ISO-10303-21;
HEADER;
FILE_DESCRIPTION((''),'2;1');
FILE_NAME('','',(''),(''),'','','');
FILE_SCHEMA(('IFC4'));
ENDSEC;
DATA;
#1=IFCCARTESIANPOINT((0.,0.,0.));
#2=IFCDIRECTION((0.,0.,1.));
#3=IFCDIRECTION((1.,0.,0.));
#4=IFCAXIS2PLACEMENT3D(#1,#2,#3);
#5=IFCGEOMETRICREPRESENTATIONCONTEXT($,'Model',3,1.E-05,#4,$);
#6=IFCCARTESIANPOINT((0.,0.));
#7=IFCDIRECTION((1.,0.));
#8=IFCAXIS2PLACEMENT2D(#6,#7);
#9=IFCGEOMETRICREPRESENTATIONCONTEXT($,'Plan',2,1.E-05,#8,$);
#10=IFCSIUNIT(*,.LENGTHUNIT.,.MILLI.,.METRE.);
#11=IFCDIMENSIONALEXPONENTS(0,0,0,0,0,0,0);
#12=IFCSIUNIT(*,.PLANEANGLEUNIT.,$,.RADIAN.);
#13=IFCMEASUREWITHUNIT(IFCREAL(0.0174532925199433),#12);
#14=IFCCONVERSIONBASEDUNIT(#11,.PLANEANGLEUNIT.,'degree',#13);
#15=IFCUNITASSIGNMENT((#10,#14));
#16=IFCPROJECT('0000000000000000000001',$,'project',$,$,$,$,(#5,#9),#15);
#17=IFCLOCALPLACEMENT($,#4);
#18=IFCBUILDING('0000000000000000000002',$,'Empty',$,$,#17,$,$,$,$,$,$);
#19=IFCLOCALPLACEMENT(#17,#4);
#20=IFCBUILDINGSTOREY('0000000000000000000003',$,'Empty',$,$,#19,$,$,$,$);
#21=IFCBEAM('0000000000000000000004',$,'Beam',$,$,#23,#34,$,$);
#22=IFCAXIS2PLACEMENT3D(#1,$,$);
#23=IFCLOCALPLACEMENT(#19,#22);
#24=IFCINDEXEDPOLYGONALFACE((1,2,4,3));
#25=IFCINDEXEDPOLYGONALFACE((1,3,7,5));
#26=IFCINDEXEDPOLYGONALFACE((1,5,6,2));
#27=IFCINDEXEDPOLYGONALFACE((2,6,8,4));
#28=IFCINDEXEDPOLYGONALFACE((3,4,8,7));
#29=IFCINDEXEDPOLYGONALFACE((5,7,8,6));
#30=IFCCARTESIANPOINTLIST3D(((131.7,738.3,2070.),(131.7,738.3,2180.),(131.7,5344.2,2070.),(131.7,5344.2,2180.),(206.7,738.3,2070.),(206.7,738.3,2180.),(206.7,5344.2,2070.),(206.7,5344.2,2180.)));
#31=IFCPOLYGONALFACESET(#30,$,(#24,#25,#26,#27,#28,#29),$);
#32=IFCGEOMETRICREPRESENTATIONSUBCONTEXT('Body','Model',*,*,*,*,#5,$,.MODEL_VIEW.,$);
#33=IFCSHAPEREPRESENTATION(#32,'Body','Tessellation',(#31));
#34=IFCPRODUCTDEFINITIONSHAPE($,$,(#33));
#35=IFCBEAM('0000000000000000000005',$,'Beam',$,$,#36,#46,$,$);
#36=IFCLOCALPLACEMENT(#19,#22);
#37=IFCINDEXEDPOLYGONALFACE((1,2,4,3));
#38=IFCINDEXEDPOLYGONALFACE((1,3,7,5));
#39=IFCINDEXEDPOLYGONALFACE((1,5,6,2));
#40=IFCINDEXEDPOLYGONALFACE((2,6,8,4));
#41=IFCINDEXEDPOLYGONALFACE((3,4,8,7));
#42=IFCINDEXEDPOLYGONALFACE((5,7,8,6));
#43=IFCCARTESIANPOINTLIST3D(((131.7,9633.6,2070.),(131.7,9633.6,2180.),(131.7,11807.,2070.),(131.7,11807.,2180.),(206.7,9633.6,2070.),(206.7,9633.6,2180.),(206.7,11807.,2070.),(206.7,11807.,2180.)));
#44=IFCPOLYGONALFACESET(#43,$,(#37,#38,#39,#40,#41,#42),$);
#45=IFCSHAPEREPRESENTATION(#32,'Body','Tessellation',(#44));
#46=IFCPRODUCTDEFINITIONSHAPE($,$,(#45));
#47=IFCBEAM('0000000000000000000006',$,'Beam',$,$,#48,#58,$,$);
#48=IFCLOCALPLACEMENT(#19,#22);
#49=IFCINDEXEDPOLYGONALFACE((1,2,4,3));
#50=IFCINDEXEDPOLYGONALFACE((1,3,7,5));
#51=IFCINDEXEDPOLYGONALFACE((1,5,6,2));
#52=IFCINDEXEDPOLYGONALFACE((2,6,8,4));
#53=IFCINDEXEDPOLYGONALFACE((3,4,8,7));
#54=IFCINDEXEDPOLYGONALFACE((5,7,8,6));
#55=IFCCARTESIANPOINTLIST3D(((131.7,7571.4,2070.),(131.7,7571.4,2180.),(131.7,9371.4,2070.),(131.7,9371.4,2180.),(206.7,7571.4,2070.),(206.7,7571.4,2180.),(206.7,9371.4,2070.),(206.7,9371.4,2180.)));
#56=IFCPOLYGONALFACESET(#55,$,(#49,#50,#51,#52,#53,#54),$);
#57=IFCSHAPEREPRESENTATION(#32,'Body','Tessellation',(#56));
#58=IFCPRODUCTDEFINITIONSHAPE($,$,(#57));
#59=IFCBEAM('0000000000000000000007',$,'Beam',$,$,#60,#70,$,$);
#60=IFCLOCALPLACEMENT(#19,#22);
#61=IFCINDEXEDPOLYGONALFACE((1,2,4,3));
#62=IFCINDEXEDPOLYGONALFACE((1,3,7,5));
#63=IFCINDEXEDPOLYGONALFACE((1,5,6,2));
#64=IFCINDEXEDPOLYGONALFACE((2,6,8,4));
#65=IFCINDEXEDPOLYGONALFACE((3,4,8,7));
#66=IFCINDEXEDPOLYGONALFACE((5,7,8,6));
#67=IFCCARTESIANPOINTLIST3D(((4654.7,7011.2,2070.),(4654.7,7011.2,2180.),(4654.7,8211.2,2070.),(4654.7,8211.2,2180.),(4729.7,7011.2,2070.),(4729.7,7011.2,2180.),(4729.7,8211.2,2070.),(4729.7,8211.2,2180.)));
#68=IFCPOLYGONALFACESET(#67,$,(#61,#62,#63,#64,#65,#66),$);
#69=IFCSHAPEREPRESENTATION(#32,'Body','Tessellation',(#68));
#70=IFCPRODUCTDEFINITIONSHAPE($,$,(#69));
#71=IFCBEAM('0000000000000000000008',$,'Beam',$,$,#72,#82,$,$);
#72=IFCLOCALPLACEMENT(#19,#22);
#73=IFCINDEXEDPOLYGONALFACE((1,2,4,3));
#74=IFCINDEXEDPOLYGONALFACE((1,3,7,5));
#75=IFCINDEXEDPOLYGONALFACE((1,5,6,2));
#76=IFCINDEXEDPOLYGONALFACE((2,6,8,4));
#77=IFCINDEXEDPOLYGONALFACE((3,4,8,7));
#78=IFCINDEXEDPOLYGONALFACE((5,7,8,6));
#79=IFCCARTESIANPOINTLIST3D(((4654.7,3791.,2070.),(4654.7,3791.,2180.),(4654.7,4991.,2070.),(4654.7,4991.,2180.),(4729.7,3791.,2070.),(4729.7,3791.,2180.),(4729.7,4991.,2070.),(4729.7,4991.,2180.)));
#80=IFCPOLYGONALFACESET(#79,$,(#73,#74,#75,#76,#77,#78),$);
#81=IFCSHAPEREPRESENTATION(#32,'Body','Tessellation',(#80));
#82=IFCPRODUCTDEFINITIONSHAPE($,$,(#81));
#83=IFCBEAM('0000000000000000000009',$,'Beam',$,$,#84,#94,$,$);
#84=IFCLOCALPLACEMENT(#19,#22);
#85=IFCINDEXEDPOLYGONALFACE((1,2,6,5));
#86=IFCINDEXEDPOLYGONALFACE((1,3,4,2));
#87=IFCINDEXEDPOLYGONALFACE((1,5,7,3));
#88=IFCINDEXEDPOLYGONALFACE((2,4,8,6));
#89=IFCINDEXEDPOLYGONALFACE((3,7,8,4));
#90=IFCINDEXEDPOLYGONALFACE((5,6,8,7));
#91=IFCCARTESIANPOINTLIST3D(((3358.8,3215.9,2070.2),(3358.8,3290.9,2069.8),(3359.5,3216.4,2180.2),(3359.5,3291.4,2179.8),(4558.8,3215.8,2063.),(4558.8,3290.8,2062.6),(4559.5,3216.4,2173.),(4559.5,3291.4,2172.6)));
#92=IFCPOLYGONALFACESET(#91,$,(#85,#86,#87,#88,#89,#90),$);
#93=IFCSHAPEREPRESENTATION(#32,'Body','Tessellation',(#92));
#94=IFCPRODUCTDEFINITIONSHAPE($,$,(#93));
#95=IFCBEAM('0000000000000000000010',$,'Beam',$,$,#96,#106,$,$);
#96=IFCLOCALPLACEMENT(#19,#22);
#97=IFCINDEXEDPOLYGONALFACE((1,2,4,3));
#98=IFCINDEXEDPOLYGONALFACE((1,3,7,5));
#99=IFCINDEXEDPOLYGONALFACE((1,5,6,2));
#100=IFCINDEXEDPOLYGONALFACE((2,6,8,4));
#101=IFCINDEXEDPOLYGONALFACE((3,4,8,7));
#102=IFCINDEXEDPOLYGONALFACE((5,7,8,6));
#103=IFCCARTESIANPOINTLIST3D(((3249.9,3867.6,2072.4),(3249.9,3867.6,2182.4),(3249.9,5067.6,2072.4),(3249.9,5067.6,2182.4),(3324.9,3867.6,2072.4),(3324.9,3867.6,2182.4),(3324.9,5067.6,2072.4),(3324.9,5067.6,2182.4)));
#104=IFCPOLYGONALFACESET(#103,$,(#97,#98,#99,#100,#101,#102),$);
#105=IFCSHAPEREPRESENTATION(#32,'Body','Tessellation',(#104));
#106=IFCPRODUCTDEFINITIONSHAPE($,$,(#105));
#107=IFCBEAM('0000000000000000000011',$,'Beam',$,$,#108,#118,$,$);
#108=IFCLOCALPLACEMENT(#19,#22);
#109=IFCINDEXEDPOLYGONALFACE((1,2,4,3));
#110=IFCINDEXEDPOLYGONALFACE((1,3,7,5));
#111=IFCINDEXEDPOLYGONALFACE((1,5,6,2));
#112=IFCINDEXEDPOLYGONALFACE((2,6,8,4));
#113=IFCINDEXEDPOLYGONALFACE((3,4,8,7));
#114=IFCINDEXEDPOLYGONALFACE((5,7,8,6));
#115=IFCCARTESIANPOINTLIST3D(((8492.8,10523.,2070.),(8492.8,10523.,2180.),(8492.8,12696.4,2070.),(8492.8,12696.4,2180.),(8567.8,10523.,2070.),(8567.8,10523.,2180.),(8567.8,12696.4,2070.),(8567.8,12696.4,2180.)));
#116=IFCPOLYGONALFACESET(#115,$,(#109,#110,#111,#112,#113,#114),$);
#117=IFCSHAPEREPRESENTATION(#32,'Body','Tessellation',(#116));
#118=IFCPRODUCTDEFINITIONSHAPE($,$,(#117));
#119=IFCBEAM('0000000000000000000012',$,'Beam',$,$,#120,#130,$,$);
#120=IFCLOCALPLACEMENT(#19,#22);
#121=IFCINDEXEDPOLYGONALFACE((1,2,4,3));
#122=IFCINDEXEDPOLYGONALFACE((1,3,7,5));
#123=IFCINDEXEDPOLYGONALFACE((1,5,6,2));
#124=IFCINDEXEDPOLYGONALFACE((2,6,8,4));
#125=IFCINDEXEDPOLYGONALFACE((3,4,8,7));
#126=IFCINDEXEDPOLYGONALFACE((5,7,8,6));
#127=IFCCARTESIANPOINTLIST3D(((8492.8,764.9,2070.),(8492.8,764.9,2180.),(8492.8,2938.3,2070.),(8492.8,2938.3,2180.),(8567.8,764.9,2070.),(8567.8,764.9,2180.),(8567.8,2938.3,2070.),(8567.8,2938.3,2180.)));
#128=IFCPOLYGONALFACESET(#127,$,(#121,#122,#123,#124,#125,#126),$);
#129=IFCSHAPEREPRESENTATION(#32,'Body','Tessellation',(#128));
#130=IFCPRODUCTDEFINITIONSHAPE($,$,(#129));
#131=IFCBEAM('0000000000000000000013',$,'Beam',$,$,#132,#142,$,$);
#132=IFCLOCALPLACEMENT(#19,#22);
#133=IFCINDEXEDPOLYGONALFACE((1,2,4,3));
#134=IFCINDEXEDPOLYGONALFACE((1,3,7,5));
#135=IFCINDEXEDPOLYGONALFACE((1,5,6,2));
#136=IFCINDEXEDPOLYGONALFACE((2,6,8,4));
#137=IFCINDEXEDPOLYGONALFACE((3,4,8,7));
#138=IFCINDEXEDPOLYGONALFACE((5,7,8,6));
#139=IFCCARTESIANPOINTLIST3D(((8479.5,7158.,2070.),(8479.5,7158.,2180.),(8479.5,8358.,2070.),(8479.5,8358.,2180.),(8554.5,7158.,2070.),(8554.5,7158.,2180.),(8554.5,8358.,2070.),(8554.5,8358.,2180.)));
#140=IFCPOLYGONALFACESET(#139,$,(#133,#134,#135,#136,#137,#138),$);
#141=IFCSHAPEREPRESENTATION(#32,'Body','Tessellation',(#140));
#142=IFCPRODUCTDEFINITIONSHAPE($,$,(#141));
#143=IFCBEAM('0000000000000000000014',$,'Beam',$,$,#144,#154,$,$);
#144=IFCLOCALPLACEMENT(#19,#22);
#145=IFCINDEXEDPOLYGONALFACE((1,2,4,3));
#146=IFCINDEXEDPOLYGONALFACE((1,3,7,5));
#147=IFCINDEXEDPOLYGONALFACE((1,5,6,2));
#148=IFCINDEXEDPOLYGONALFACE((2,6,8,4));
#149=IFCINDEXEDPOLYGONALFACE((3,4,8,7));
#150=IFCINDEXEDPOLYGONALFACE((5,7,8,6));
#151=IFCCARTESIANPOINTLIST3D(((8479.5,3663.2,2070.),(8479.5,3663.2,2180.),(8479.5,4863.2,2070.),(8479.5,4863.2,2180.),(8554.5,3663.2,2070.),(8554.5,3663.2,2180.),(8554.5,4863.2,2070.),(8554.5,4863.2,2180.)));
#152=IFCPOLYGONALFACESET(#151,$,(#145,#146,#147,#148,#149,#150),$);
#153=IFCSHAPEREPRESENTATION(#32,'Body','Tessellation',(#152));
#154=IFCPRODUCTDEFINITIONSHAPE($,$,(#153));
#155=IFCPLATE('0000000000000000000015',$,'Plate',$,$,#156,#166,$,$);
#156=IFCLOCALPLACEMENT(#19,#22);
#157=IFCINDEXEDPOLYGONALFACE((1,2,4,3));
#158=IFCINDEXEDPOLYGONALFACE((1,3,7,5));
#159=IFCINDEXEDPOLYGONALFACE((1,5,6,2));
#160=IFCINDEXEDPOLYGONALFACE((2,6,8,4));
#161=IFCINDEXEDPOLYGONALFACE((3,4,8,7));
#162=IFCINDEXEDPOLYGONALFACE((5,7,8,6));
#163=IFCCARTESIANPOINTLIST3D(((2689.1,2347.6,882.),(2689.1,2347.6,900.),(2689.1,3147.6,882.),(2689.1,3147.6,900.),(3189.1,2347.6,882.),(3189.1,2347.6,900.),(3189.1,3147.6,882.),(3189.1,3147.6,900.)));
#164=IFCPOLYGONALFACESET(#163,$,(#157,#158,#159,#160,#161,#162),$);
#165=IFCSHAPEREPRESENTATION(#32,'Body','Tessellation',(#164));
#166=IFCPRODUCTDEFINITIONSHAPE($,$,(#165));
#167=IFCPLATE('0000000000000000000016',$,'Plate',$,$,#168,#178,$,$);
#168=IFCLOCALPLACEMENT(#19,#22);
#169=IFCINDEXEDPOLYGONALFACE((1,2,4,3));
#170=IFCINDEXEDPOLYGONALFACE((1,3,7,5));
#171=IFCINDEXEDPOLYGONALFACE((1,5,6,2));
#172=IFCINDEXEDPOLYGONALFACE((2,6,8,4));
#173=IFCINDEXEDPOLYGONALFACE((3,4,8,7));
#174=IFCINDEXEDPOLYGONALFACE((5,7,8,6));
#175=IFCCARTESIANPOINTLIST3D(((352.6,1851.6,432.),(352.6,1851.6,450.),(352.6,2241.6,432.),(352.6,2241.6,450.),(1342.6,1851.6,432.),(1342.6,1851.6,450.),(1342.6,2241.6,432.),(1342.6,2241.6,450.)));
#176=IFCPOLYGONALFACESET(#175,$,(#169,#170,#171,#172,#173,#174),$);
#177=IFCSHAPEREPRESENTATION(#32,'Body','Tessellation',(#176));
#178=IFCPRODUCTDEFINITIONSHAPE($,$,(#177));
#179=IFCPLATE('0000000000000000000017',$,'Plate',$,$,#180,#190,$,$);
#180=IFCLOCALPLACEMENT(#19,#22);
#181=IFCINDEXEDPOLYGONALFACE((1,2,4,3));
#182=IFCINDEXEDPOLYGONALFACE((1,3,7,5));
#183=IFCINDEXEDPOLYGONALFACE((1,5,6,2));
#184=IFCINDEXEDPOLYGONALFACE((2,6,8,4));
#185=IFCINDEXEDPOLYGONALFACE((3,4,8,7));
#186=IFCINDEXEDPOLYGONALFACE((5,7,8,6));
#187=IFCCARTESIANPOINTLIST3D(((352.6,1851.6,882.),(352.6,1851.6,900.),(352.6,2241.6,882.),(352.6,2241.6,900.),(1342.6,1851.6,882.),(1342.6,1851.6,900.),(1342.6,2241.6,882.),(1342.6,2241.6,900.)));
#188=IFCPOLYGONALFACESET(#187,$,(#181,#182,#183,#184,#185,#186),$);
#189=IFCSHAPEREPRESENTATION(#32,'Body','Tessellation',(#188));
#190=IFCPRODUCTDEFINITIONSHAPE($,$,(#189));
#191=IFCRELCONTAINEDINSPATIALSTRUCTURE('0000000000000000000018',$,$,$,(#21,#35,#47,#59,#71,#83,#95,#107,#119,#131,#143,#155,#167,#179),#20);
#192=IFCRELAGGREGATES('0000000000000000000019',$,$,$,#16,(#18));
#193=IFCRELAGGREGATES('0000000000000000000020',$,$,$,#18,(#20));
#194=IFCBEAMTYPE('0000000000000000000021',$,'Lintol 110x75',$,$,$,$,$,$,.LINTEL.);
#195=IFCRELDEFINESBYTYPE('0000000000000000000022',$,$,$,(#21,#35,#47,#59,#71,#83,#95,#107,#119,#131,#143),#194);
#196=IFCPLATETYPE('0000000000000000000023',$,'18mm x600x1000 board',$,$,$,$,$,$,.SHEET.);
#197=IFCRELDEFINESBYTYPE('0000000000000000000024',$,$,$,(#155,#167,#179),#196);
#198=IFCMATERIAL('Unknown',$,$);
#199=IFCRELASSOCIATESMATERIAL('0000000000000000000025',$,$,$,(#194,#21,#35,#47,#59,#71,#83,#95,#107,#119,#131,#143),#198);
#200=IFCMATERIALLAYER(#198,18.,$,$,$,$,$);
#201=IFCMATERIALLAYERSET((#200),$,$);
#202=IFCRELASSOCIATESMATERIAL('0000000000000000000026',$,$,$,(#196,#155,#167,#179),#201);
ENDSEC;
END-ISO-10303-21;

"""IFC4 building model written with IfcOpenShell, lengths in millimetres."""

from ifc_helpers import new_model, entity, si_unit, converted_unit, frame, origin_with_axes, origin_2d_with_axis, place, context, subcontext, project, spatial, line, indexed_curve, rectangle, outline, extrude, material, layer, layer_set, layer_usage, material_profile, profile_set, profile_usage, type_object, element, save


model = new_model("IFC4")

# Units and contexts
model_context = context("Model", 3, precision=1e-05, world=origin_with_axes())
plan_context = context("Plan", 2, precision=1e-05, world=origin_2d_with_axis())
body_context = subcontext(model_context, "Body", "Model", "MODEL_VIEW")
ifc_project = project(units=[si_unit("LENGTHUNIT", "METRE", prefix="MILLI"), converted_unit("PLANEANGLEUNIT", "degree", entity("IfcReal", 0.0174532925199433), si_unit("PLANEANGLEUNIT", "RADIAN"), dimensions=[0, 0, 0, 0, 0, 0, 0])], contexts=[model_context, plan_context])

# Building, storey
building_placement = place(None, origin_with_axes())
building = spatial("IfcBuilding", under=ifc_project, at=building_placement, Name="Empty")
storey_placement = place(building_placement, origin_with_axes())
storey = spatial("IfcBuildingStorey", under=building, at=storey_placement, Name="Empty")

# Beams
ifc_material_1 = material(Name="Unknown")
ifc_material_profile_1 = material_profile(ifc_material_1, rectangle(XDim=75.0, YDim=110.0))
ifc_profile_set_1 = profile_set([ifc_material_profile_1])
ifc_profile_usage_1 = profile_usage(ifc_profile_set_1, cardinal=5)
beam_type = type_object("IfcBeamType", Name="Lintol 110x75", PredefinedType="LINTEL", material=ifc_profile_set_1)
beam_1_placement = place(storey_placement, frame((169.2, 738.3, 2125.0), z_axis=(0.0, 1.0, 0.0), x_axis=(-1.0, 0.0, 0.0)))
element("IfcBeam", 1, at=beam_1_placement, inside=storey, type_object=beam_type, material=ifc_profile_usage_1, Name="Beam", context=body_context, shape_type="SweptSolid", body=[
    extrude(rectangle(XDim=75.0, YDim=110.0), origin_with_axes(), (0.0, 0.0, 1.0), 4605.9),
])
ifc_profile_usage_2 = profile_usage(ifc_profile_set_1, cardinal=5)
beam_2_placement = place(storey_placement, frame((169.2, 9633.6, 2125.0), z_axis=(-0.000001, 1.0, 0.0), x_axis=(-1.0, -0.000001, 0.0)))
element("IfcBeam", 2, at=beam_2_placement, inside=storey, type_object=beam_type, material=ifc_profile_usage_2, Name="Beam", context=body_context, shape_type="SweptSolid", body=[
    extrude(rectangle(XDim=75.0, YDim=110.0), origin_with_axes(), (0.0, 0.0, 1.0), 2173.4),
])
ifc_profile_usage_3 = profile_usage(ifc_profile_set_1, cardinal=5)
beam_3_placement = place(storey_placement, frame((169.2, 9371.4, 2125.0), z_axis=(-0.000001, -1.0, 0.0), x_axis=(1.0, -0.000001, 0.0)))
element("IfcBeam", 3, at=beam_3_placement, inside=storey, type_object=beam_type, material=ifc_profile_usage_3, Name="Beam", context=body_context, shape_type="SweptSolid", body=[
    extrude(rectangle(XDim=75.0, YDim=110.0), origin_with_axes(), (0.0, 0.0, 1.0), 1800.0),
])
ifc_profile_usage_4 = profile_usage(ifc_profile_set_1, cardinal=5)
beam_4_placement = place(storey_placement, frame((4692.2, 8211.2, 2125.0), z_axis=(0.000001, -1.0, 0.000001), x_axis=(1.0, 0.000001, 0.0)))
element("IfcBeam", 4, at=beam_4_placement, inside=storey, type_object=beam_type, material=ifc_profile_usage_4, Name="Beam", context=body_context, shape_type="SweptSolid", body=[
    extrude(rectangle(XDim=75.0, YDim=110.0), origin_with_axes(), (0.0, 0.0, 1.0), 1200.0),
])
ifc_profile_usage_5 = profile_usage(ifc_profile_set_1, cardinal=5)
beam_5_placement = place(storey_placement, frame((4692.2, 4991.0, 2125.0), z_axis=(0.000001, -1.0, 0.000001), x_axis=(1.0, 0.000001, 0.0)))
element("IfcBeam", 5, at=beam_5_placement, inside=storey, type_object=beam_type, material=ifc_profile_usage_5, Name="Beam", context=body_context, shape_type="SweptSolid", body=[
    extrude(rectangle(XDim=75.0, YDim=110.0), origin_with_axes(), (0.0, 0.0, 1.0), 1200.0),
])
ifc_profile_usage_6 = profile_usage(ifc_profile_set_1, cardinal=5)
beam_6_placement = place(storey_placement, frame((3359.2, 3253.6, 2125.0), z_axis=(0.999982, -0.000031, -0.006032), x_axis=(0.0, 0.999987, -0.005098)))
element("IfcBeam", 6, at=beam_6_placement, inside=storey, type_object=beam_type, material=ifc_profile_usage_6, Name="Beam", context=body_context, shape_type="SweptSolid", body=[
    extrude(rectangle(XDim=75.0, YDim=110.0), origin_with_axes(), (0.0, 0.0, 1.0), 1200.0),
])
ifc_profile_usage_7 = profile_usage(ifc_profile_set_1, cardinal=5)
beam_7_placement = place(storey_placement, frame((3287.4, 5067.6, 2127.4), z_axis=(0.0, -1.0, 0.0), x_axis=(1.0, 0.0, 0.0)))
element("IfcBeam", 7, at=beam_7_placement, inside=storey, type_object=beam_type, material=ifc_profile_usage_7, Name="Beam", context=body_context, shape_type="SweptSolid", body=[
    extrude(rectangle(XDim=75.0, YDim=110.0), origin_with_axes(), (0.0, 0.0, 1.0), 1200.0),
])
ifc_profile_usage_8 = profile_usage(ifc_profile_set_1, cardinal=5)
beam_8_placement = place(storey_placement, frame((8530.3, 10523.0, 2125.0), z_axis=(0.0, 1.0, 0.0), x_axis=(-1.0, 0.0, 0.0)))
element("IfcBeam", 8, at=beam_8_placement, inside=storey, type_object=beam_type, material=ifc_profile_usage_8, Name="Beam", context=body_context, shape_type="SweptSolid", body=[
    extrude(rectangle(XDim=75.0, YDim=110.0), origin_with_axes(), (0.0, 0.0, 1.0), 2173.4),
])
ifc_profile_usage_9 = profile_usage(ifc_profile_set_1, cardinal=5)
beam_9_placement = place(storey_placement, frame((8530.3, 764.9, 2125.0), z_axis=(0.0, 1.0, 0.0), x_axis=(-1.0, 0.0, 0.0)))
element("IfcBeam", 9, at=beam_9_placement, inside=storey, type_object=beam_type, material=ifc_profile_usage_9, Name="Beam", context=body_context, shape_type="SweptSolid", body=[
    extrude(rectangle(XDim=75.0, YDim=110.0), origin_with_axes(), (0.0, 0.0, 1.0), 2173.4),
])
ifc_profile_usage_10 = profile_usage(ifc_profile_set_1, cardinal=5)
beam_10_placement = place(storey_placement, frame((8517.0, 8358.0, 2125.0), z_axis=(0.000001, -1.0, 0.000001), x_axis=(1.0, 0.000001, 0.0)))
element("IfcBeam", 10, at=beam_10_placement, inside=storey, type_object=beam_type, material=ifc_profile_usage_10, Name="Beam", context=body_context, shape_type="SweptSolid", body=[
    extrude(rectangle(XDim=75.0, YDim=110.0), origin_with_axes(), (0.0, 0.0, 1.0), 1200.0),
])
ifc_profile_usage_11 = profile_usage(ifc_profile_set_1, cardinal=5)
beam_11_placement = place(storey_placement, frame((8517.0, 4863.2, 2125.0), z_axis=(0.000001, -1.0, 0.000001), x_axis=(1.0, 0.000001, 0.0)))
element("IfcBeam", 11, at=beam_11_placement, inside=storey, type_object=beam_type, material=ifc_profile_usage_11, Name="Beam", context=body_context, shape_type="SweptSolid", body=[
    extrude(rectangle(XDim=75.0, YDim=110.0), origin_with_axes(), (0.0, 0.0, 1.0), 1200.0),
])

# Plates
ifc_layer_1 = layer(ifc_material_1, 18.0)
ifc_layer_set_1 = layer_set([ifc_layer_1])
plate_type = type_object("IfcPlateType", Name="18mm x600x1000 board", PredefinedType="SHEET", material=ifc_layer_set_1)
ifc_layer_usage_1 = layer_usage(ifc_layer_set_1, "AXIS3", "POSITIVE", 0.0)
plate_1_placement = place(storey_placement, frame((2689.1, 3147.6, 882.0), z_axis=(0.0, 0.0, 1.0), x_axis=(0.000002, -1.0, 0.0)))
element("IfcPlate", 12, at=plate_1_placement, inside=storey, type_object=plate_type, material=ifc_layer_usage_1, Name="Plate", context=body_context, shape_type="SweptSolid", body=[
    extrude(outline(indexed_curve([(0.0, 500.0), (0.0, 0.0), (800.0, 0.0), (800.0, 500.0)], segments=[line(3, 2), line(2, 1), line(1, 4), line(4, 3)], self_intersect=False)), None, (0.0, 0.0, 1.0), 18.0),
])
ifc_layer_usage_2 = layer_usage(ifc_layer_set_1, "AXIS3", "POSITIVE", 0.0)
plate_2_placement = place(storey_placement, frame((352.6, 1851.6, 432.0), z_axis=(0.0, 0.0, 1.0), x_axis=(1.0, 0.000001, 0.0)))
element("IfcPlate", 13, at=plate_2_placement, inside=storey, type_object=plate_type, material=ifc_layer_usage_2, Name="Plate", context=body_context, shape_type="SweptSolid", body=[
    extrude(outline(indexed_curve([(0.0, 390.0), (0.0, 0.0), (990.0, 0.0), (990.0, 390.0)], segments=[line(4, 1), line(1, 2), line(2, 3), line(3, 4)], self_intersect=False)), None, (0.0, 0.0, 1.0), 18.0),
])
ifc_layer_usage_3 = layer_usage(ifc_layer_set_1, "AXIS3", "POSITIVE", 0.0)
plate_3_placement = place(storey_placement, frame((352.6, 1851.6, 882.0), z_axis=(0.0, 0.0, 1.0), x_axis=(1.0, 0.000001, 0.0)))
element("IfcPlate", 14, at=plate_3_placement, inside=storey, type_object=plate_type, material=ifc_layer_usage_3, Name="Plate", context=body_context, shape_type="SweptSolid", body=[
    extrude(outline(indexed_curve([(0.0, 390.0), (0.0, 0.0), (990.0, 0.0), (990.0, 390.0)], segments=[line(4, 1), line(1, 2), line(2, 3), line(3, 4)], self_intersect=False)), None, (0.0, 0.0, 1.0), 18.0),
])

save(model, "model.ifc")
